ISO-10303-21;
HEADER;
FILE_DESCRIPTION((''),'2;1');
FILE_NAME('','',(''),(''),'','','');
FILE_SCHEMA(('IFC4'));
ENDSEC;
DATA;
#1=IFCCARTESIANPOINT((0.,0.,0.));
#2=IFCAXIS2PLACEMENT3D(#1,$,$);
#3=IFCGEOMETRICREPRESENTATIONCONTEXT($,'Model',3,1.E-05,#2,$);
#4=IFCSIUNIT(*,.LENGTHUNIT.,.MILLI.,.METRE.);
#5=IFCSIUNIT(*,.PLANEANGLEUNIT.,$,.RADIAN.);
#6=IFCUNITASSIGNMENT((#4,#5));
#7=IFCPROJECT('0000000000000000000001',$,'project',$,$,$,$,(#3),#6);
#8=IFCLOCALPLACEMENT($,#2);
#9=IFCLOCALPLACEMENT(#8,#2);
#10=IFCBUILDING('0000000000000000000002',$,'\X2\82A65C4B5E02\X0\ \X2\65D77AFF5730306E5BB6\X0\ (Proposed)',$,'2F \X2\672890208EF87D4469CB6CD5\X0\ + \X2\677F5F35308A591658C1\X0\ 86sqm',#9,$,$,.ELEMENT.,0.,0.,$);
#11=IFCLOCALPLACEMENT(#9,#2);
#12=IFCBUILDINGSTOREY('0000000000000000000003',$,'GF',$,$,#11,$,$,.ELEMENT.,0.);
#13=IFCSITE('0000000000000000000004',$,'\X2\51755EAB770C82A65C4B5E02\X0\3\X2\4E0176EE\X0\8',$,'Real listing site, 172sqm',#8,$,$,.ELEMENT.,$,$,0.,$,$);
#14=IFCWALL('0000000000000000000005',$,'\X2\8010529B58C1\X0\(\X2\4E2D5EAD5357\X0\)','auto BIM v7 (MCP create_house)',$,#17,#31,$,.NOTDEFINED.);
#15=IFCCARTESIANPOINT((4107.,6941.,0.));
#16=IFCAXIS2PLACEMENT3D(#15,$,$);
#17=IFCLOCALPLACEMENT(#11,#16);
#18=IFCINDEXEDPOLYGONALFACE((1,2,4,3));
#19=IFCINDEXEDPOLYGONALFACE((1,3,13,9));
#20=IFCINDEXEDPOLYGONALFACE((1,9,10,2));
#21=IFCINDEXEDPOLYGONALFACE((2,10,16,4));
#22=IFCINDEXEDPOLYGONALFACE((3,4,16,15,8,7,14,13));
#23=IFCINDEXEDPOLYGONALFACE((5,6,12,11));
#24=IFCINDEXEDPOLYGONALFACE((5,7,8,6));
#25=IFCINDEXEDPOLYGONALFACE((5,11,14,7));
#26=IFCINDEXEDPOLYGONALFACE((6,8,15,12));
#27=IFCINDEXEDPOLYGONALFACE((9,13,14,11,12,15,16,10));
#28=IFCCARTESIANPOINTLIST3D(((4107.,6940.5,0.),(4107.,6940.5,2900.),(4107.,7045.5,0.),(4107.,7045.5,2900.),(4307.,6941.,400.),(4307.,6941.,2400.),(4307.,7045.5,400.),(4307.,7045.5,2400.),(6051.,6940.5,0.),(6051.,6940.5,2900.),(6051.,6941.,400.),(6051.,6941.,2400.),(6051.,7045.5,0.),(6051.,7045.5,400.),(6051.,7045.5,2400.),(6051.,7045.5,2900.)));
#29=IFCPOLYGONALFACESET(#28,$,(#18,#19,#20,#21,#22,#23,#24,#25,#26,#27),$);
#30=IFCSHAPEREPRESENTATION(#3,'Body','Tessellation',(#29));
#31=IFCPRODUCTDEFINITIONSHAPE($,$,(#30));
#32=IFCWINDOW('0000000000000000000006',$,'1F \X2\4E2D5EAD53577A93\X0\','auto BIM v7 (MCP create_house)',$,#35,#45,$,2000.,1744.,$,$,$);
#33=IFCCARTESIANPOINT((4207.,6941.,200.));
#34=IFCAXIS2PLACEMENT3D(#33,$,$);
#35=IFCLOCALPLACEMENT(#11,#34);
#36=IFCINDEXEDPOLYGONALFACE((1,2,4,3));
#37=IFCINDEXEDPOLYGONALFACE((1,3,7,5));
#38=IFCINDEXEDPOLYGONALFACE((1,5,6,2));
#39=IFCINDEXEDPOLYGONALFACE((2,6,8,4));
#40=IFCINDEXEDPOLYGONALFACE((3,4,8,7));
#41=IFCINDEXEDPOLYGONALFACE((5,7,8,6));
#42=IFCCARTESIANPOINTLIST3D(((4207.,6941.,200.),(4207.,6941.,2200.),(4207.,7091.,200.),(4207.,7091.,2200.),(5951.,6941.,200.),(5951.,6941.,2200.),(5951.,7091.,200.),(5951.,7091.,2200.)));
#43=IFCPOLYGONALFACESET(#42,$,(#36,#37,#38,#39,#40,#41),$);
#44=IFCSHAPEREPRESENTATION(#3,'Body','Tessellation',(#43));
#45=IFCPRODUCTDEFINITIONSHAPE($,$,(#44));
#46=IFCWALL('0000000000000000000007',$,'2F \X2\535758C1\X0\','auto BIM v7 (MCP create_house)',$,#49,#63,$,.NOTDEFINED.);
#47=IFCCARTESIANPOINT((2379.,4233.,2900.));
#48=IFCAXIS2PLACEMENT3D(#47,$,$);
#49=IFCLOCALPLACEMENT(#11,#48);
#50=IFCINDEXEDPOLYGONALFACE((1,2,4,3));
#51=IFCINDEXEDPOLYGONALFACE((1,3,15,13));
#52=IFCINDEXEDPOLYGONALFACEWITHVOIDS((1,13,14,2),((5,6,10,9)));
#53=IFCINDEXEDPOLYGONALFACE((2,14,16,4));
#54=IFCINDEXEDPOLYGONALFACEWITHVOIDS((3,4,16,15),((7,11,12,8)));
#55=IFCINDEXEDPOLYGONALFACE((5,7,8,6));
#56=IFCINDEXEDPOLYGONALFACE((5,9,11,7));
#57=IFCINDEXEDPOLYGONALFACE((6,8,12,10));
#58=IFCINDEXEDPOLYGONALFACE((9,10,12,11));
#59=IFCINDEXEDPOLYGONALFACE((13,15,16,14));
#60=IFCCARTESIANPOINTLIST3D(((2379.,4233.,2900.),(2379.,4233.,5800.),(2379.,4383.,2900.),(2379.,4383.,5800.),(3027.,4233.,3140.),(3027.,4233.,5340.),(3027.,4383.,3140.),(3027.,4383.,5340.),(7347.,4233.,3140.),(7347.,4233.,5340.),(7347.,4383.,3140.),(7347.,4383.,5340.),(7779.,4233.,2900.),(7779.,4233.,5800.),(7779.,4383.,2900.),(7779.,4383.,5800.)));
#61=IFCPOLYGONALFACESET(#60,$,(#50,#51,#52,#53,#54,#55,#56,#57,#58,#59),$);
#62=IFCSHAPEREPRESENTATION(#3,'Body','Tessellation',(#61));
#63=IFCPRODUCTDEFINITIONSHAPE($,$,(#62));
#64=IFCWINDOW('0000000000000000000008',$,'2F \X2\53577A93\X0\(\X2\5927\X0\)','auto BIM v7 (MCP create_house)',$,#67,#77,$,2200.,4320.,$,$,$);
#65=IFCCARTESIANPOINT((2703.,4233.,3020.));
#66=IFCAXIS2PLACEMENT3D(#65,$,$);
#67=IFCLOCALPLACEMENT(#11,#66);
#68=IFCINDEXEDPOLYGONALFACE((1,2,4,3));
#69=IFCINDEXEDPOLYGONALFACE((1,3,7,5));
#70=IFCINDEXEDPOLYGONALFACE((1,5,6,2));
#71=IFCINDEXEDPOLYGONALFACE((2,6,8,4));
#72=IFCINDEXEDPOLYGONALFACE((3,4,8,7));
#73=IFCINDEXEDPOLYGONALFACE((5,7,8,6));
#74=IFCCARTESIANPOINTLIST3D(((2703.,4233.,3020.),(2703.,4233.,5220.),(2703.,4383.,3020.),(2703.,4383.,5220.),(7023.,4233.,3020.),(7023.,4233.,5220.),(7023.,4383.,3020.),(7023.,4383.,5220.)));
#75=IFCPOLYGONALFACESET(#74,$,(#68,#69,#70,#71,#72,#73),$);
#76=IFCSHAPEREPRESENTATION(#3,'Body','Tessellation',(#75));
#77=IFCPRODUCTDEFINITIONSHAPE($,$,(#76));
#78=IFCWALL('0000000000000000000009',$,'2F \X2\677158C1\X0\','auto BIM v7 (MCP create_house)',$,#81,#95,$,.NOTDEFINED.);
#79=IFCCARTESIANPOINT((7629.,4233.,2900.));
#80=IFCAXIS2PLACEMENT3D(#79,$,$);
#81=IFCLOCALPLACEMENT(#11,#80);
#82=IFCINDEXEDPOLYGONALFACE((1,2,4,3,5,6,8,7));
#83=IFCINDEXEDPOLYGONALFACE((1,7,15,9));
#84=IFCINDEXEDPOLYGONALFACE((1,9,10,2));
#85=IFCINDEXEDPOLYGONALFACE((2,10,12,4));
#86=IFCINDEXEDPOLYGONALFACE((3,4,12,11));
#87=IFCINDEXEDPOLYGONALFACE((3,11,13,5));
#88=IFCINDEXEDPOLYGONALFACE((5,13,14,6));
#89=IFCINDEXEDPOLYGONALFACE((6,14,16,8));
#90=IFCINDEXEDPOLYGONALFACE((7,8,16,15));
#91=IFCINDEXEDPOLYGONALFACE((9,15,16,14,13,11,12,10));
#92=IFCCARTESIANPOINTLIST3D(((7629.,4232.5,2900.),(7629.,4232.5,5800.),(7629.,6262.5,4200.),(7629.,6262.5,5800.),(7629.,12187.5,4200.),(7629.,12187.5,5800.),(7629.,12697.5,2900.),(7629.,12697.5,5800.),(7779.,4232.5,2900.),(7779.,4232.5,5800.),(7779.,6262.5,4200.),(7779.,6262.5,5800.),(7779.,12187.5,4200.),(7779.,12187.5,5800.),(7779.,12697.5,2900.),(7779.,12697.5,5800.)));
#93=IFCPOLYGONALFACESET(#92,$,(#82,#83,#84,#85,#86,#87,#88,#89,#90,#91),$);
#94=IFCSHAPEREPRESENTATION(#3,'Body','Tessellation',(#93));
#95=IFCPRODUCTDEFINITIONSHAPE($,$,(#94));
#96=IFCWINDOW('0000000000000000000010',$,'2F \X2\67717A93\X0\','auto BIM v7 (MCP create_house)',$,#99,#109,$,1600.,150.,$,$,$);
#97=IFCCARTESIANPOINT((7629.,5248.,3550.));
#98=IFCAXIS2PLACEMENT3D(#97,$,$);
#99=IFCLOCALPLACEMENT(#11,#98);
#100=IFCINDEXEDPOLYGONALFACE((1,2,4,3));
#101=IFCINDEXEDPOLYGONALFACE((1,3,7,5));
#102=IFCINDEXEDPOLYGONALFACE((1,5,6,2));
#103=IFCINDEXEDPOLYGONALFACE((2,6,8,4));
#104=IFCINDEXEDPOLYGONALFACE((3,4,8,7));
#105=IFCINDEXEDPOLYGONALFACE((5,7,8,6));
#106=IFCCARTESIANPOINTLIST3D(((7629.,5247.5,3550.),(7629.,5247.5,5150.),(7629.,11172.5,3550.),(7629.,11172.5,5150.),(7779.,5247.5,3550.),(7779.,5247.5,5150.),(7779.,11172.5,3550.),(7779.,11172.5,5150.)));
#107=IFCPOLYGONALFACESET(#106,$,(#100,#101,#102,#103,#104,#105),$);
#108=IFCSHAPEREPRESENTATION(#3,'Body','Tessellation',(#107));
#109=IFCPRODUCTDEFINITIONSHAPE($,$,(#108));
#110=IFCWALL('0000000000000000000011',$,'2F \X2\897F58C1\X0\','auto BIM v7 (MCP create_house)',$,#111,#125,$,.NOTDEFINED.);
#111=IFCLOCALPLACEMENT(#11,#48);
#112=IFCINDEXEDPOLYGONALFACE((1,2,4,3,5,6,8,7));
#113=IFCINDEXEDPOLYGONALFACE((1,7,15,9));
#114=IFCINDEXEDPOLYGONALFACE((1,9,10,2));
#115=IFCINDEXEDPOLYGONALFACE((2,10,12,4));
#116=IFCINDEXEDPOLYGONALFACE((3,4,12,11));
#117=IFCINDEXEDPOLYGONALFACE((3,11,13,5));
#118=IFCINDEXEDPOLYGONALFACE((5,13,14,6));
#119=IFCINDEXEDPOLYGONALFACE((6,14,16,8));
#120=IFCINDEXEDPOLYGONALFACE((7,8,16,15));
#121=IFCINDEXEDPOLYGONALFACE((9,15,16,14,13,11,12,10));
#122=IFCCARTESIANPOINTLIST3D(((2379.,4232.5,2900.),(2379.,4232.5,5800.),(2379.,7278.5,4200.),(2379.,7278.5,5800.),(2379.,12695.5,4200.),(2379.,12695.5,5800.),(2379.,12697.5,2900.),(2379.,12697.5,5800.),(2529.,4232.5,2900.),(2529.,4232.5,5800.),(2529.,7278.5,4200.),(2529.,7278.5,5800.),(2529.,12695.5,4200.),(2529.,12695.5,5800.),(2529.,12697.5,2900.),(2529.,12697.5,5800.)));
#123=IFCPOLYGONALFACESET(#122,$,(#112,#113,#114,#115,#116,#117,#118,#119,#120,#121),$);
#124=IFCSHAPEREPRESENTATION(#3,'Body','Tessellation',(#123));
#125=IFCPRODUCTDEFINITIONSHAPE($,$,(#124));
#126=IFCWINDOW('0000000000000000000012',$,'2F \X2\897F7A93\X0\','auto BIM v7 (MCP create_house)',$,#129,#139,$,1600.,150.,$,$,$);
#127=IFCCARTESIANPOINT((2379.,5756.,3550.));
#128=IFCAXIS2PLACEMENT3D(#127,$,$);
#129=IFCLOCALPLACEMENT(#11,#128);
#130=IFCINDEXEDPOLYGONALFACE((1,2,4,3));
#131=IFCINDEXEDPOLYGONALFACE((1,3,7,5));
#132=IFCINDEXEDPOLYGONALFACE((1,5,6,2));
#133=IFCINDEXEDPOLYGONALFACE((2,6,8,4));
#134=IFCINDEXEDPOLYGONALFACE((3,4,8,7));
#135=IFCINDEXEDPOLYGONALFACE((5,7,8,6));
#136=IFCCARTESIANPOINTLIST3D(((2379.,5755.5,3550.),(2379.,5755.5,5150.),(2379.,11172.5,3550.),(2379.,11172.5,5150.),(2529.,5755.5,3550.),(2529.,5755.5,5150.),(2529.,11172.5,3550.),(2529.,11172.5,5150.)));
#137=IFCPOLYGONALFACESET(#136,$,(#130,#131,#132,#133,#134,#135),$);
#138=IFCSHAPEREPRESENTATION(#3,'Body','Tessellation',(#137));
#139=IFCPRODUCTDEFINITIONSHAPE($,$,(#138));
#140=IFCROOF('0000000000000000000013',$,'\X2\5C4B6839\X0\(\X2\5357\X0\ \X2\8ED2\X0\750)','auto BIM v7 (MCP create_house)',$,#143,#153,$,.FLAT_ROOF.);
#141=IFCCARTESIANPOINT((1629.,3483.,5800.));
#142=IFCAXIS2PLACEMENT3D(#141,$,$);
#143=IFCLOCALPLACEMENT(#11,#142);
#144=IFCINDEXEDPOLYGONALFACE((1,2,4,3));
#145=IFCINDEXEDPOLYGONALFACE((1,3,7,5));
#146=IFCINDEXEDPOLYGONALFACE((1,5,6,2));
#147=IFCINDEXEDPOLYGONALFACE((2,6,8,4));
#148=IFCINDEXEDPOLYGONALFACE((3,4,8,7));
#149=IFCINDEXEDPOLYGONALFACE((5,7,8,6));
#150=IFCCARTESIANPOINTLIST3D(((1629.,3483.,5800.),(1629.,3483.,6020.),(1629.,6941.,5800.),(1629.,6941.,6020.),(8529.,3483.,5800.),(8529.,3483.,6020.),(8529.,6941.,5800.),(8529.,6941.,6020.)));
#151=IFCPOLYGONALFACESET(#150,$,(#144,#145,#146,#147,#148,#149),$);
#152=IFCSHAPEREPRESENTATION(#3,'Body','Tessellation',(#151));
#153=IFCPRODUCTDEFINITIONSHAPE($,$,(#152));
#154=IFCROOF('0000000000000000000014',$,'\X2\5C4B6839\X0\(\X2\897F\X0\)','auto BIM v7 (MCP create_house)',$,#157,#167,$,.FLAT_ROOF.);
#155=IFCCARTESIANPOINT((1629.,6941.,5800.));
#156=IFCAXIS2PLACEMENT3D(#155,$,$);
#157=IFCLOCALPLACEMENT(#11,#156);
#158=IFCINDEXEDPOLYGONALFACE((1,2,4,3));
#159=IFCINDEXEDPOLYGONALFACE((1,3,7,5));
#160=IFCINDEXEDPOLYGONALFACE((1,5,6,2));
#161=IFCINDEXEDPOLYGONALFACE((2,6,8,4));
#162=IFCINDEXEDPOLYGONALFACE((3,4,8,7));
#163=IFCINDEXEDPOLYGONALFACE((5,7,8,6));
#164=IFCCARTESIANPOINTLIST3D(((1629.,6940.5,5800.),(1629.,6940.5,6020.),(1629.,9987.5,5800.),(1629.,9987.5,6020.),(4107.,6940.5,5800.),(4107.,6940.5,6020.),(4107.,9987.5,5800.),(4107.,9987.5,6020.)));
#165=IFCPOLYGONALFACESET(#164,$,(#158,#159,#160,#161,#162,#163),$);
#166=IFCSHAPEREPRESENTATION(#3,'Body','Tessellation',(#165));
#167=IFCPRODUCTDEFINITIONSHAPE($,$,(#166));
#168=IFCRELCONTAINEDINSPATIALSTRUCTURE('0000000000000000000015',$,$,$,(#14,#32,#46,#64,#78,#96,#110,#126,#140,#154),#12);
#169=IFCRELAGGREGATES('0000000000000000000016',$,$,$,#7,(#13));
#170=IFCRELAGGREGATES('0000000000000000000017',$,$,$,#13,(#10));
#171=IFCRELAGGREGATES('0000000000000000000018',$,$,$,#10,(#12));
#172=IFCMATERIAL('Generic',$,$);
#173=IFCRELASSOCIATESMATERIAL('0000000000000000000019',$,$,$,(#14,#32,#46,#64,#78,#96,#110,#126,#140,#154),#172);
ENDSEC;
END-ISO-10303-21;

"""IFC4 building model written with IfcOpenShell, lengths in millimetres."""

from ifc_helpers import new_model, si_unit, frame, frame_2d, origin, place, context, project, spatial, rectangle, extrude, material, element, fill, save


model = new_model("IFC4")

# Units and contexts
model_context = context("Model", 3, precision=1e-05, world=origin())
ifc_project = project(units=[si_unit("LENGTHUNIT", "METRE", prefix="MILLI"), si_unit("PLANEANGLEUNIT", "RADIAN")], contexts=[model_context])

# Site, building, storey
site_placement = place(None, origin())
site = spatial("IfcSite", under=ifc_project, at=site_placement, Name="兵庫県芦屋市3丁目8", ObjectType="Real listing site, 172sqm", CompositionType="ELEMENT", RefElevation=0.0)
building_placement = place(site_placement, origin())
building = spatial("IfcBuilding", under=site, at=building_placement, Name="芦屋市 旗竿地の家 (Proposed)", ObjectType="2F 木造軸組構法 + 板張り外壁 86sqm", CompositionType="ELEMENT", ElevationOfRefHeight=0.0, ElevationOfTerrain=0.0)
storey_placement = place(building_placement, origin())
storey = spatial("IfcBuildingStorey", under=building, at=storey_placement, Name="GF", CompositionType="ELEMENT", Elevation=0.0)

# Shared definitions
ifc_material = material(Name="Generic")

# Wall, opening, window
wall_1_placement = place(storey_placement, frame((4107.0, 6941.0, 0.0)))
wall_1 = element("IfcWall", 1, at=wall_1_placement, inside=storey, material=ifc_material, Name="耐力壁(中庭南)", Description="auto BIM v7 (MCP create_house)", PredefinedType="NOTDEFINED", context=model_context, shape_type="SweptSolid", body=[
    extrude(rectangle(XDim=1944.0, YDim=105.0, at=frame_2d((972.0, 52.0))), frame((4107.0, 6941.0, 0.0)), (0.0, 0.0, 1.0), 2900.0),
])
opening_1_placement = place(storey_placement, frame((4207.0, 6941.0, 200.0)))
opening_1 = element("IfcOpeningElement", 2, at=opening_1_placement, cuts=wall_1, PredefinedType="NOTDEFINED", context=model_context, shape_type="SweptSolid", body=[
    extrude(rectangle(XDim=1744.0, YDim=150.0, at=frame_2d((872.0, 75.0))), frame((4207.0, 6941.0, 200.0)), (0.0, 0.0, 1.0), 2000.0),
])
window_1_placement = place(storey_placement, frame((4207.0, 6941.0, 200.0)))
window_1 = element("IfcWindow", 3, at=window_1_placement, inside=storey, material=ifc_material, Name="1F 中庭南窓", Description="auto BIM v7 (MCP create_house)", OverallHeight=2000.0, OverallWidth=1744.0, context=model_context, shape_type="SweptSolid", body=[
    extrude(rectangle(XDim=1744.0, YDim=150.0, at=frame_2d((872.0, 75.0))), frame((4207.0, 6941.0, 200.0)), (0.0, 0.0, 1.0), 2000.0),
])
fill(opening_1, window_1)

# Walls, openings, windows
wall_2_placement = place(storey_placement, frame((2379.0, 4233.0, 2900.0)))
wall_2 = element("IfcWall", 4, at=wall_2_placement, inside=storey, material=ifc_material, Name="2F 南壁", Description="auto BIM v7 (MCP create_house)", PredefinedType="NOTDEFINED", context=model_context, shape_type="SweptSolid", body=[
    extrude(rectangle(XDim=5400.0, YDim=150.0, at=frame_2d((2700.0, 75.0))), frame((2379.0, 4233.0, 2900.0)), (0.0, 0.0, 1.0), 2900.0),
])
opening_2_placement = place(storey_placement, frame((2703.0, 4233.0, 3020.0)))
opening_2 = element("IfcOpeningElement", 5, at=opening_2_placement, cuts=wall_2, PredefinedType="NOTDEFINED", context=model_context, shape_type="SweptSolid", body=[
    extrude(rectangle(XDim=4320.0, YDim=150.0, at=frame_2d((2160.0, 75.0))), frame((2703.0, 4233.0, 3020.0)), (0.0, 0.0, 1.0), 2200.0),
])
window_2_placement = place(storey_placement, frame((2703.0, 4233.0, 3020.0)))
window_2 = element("IfcWindow", 6, at=window_2_placement, inside=storey, material=ifc_material, Name="2F 南窓(大)", Description="auto BIM v7 (MCP create_house)", OverallHeight=2200.0, OverallWidth=4320.0, context=model_context, shape_type="SweptSolid", body=[
    extrude(rectangle(XDim=4320.0, YDim=150.0, at=frame_2d((2160.0, 75.0))), frame((2703.0, 4233.0, 3020.0)), (0.0, 0.0, 1.0), 2200.0),
])
fill(opening_2, window_2)
wall_3_placement = place(storey_placement, frame((7629.0, 4233.0, 2900.0)))
wall_3 = element("IfcWall", 7, at=wall_3_placement, inside=storey, material=ifc_material, Name="2F 東壁", Description="auto BIM v7 (MCP create_house)", PredefinedType="NOTDEFINED", context=model_context, shape_type="SweptSolid", body=[
    extrude(rectangle(XDim=150.0, YDim=8465.0, at=frame_2d((75.0, 4232.0))), frame((7629.0, 4233.0, 2900.0)), (0.0, 0.0, 1.0), 2900.0),
])
opening_3_placement = place(storey_placement, frame((7629.0, 5248.0, 3550.0)))
opening_3 = element("IfcOpeningElement", 8, at=opening_3_placement, cuts=wall_3, PredefinedType="NOTDEFINED", context=model_context, shape_type="SweptSolid", body=[
    extrude(rectangle(XDim=150.0, YDim=5925.0, at=frame_2d((75.0, 2962.0))), frame((7629.0, 5248.0, 3550.0)), (0.0, 0.0, 1.0), 1600.0),
])
window_3_placement = place(storey_placement, frame((7629.0, 5248.0, 3550.0)))
window_3 = element("IfcWindow", 9, at=window_3_placement, inside=storey, material=ifc_material, Name="2F 東窓", Description="auto BIM v7 (MCP create_house)", OverallHeight=1600.0, OverallWidth=150.0, context=model_context, shape_type="SweptSolid", body=[
    extrude(rectangle(XDim=150.0, YDim=5925.0, at=frame_2d((75.0, 2962.0))), frame((7629.0, 5248.0, 3550.0)), (0.0, 0.0, 1.0), 1600.0),
])
fill(opening_3, window_3)
wall_4_placement = place(storey_placement, frame((2379.0, 4233.0, 2900.0)))
wall_4 = element("IfcWall", 10, at=wall_4_placement, inside=storey, material=ifc_material, Name="2F 西壁", Description="auto BIM v7 (MCP create_house)", PredefinedType="NOTDEFINED", context=model_context, shape_type="SweptSolid", body=[
    extrude(rectangle(XDim=150.0, YDim=8465.0, at=frame_2d((75.0, 4232.0))), frame((2379.0, 4233.0, 2900.0)), (0.0, 0.0, 1.0), 2900.0),
])
opening_4_placement = place(storey_placement, frame((2379.0, 5756.0, 3550.0)))
opening_4 = element("IfcOpeningElement", 11, at=opening_4_placement, cuts=wall_4, PredefinedType="NOTDEFINED", context=model_context, shape_type="SweptSolid", body=[
    extrude(rectangle(XDim=150.0, YDim=5417.0, at=frame_2d((75.0, 2708.0))), frame((2379.0, 5756.0, 3550.0)), (0.0, 0.0, 1.0), 1600.0),
])
window_4_placement = place(storey_placement, frame((2379.0, 5756.0, 3550.0)))
window_4 = element("IfcWindow", 12, at=window_4_placement, inside=storey, material=ifc_material, Name="2F 西窓", Description="auto BIM v7 (MCP create_house)", OverallHeight=1600.0, OverallWidth=150.0, context=model_context, shape_type="SweptSolid", body=[
    extrude(rectangle(XDim=150.0, YDim=5417.0, at=frame_2d((75.0, 2708.0))), frame((2379.0, 5756.0, 3550.0)), (0.0, 0.0, 1.0), 1600.0),
])
fill(opening_4, window_4)

# Roofs
roof_1_placement = place(storey_placement, frame((1629.0, 3483.0, 5800.0)))
element("IfcRoof", 13, at=roof_1_placement, inside=storey, material=ifc_material, Name="屋根(南 軒750)", Description="auto BIM v7 (MCP create_house)", PredefinedType="FLAT_ROOF", context=model_context, shape_type="SweptSolid", body=[
    extrude(rectangle(XDim=6900.0, YDim=3458.0, at=frame_2d((3450.0, 1729.0))), frame((1629.0, 3483.0, 5800.0)), (0.0, 0.0, 1.0), 220.0),
])
roof_2_placement = place(storey_placement, frame((1629.0, 6941.0, 5800.0)))
element("IfcRoof", 14, at=roof_2_placement, inside=storey, material=ifc_material, Name="屋根(西)", Description="auto BIM v7 (MCP create_house)", PredefinedType="FLAT_ROOF", context=model_context, shape_type="SweptSolid", body=[
    extrude(rectangle(XDim=2478.0, YDim=3047.0, at=frame_2d((1239.0, 1523.0))), frame((1629.0, 6941.0, 5800.0)), (0.0, 0.0, 1.0), 220.0),
])

save(model, "model.ifc")
